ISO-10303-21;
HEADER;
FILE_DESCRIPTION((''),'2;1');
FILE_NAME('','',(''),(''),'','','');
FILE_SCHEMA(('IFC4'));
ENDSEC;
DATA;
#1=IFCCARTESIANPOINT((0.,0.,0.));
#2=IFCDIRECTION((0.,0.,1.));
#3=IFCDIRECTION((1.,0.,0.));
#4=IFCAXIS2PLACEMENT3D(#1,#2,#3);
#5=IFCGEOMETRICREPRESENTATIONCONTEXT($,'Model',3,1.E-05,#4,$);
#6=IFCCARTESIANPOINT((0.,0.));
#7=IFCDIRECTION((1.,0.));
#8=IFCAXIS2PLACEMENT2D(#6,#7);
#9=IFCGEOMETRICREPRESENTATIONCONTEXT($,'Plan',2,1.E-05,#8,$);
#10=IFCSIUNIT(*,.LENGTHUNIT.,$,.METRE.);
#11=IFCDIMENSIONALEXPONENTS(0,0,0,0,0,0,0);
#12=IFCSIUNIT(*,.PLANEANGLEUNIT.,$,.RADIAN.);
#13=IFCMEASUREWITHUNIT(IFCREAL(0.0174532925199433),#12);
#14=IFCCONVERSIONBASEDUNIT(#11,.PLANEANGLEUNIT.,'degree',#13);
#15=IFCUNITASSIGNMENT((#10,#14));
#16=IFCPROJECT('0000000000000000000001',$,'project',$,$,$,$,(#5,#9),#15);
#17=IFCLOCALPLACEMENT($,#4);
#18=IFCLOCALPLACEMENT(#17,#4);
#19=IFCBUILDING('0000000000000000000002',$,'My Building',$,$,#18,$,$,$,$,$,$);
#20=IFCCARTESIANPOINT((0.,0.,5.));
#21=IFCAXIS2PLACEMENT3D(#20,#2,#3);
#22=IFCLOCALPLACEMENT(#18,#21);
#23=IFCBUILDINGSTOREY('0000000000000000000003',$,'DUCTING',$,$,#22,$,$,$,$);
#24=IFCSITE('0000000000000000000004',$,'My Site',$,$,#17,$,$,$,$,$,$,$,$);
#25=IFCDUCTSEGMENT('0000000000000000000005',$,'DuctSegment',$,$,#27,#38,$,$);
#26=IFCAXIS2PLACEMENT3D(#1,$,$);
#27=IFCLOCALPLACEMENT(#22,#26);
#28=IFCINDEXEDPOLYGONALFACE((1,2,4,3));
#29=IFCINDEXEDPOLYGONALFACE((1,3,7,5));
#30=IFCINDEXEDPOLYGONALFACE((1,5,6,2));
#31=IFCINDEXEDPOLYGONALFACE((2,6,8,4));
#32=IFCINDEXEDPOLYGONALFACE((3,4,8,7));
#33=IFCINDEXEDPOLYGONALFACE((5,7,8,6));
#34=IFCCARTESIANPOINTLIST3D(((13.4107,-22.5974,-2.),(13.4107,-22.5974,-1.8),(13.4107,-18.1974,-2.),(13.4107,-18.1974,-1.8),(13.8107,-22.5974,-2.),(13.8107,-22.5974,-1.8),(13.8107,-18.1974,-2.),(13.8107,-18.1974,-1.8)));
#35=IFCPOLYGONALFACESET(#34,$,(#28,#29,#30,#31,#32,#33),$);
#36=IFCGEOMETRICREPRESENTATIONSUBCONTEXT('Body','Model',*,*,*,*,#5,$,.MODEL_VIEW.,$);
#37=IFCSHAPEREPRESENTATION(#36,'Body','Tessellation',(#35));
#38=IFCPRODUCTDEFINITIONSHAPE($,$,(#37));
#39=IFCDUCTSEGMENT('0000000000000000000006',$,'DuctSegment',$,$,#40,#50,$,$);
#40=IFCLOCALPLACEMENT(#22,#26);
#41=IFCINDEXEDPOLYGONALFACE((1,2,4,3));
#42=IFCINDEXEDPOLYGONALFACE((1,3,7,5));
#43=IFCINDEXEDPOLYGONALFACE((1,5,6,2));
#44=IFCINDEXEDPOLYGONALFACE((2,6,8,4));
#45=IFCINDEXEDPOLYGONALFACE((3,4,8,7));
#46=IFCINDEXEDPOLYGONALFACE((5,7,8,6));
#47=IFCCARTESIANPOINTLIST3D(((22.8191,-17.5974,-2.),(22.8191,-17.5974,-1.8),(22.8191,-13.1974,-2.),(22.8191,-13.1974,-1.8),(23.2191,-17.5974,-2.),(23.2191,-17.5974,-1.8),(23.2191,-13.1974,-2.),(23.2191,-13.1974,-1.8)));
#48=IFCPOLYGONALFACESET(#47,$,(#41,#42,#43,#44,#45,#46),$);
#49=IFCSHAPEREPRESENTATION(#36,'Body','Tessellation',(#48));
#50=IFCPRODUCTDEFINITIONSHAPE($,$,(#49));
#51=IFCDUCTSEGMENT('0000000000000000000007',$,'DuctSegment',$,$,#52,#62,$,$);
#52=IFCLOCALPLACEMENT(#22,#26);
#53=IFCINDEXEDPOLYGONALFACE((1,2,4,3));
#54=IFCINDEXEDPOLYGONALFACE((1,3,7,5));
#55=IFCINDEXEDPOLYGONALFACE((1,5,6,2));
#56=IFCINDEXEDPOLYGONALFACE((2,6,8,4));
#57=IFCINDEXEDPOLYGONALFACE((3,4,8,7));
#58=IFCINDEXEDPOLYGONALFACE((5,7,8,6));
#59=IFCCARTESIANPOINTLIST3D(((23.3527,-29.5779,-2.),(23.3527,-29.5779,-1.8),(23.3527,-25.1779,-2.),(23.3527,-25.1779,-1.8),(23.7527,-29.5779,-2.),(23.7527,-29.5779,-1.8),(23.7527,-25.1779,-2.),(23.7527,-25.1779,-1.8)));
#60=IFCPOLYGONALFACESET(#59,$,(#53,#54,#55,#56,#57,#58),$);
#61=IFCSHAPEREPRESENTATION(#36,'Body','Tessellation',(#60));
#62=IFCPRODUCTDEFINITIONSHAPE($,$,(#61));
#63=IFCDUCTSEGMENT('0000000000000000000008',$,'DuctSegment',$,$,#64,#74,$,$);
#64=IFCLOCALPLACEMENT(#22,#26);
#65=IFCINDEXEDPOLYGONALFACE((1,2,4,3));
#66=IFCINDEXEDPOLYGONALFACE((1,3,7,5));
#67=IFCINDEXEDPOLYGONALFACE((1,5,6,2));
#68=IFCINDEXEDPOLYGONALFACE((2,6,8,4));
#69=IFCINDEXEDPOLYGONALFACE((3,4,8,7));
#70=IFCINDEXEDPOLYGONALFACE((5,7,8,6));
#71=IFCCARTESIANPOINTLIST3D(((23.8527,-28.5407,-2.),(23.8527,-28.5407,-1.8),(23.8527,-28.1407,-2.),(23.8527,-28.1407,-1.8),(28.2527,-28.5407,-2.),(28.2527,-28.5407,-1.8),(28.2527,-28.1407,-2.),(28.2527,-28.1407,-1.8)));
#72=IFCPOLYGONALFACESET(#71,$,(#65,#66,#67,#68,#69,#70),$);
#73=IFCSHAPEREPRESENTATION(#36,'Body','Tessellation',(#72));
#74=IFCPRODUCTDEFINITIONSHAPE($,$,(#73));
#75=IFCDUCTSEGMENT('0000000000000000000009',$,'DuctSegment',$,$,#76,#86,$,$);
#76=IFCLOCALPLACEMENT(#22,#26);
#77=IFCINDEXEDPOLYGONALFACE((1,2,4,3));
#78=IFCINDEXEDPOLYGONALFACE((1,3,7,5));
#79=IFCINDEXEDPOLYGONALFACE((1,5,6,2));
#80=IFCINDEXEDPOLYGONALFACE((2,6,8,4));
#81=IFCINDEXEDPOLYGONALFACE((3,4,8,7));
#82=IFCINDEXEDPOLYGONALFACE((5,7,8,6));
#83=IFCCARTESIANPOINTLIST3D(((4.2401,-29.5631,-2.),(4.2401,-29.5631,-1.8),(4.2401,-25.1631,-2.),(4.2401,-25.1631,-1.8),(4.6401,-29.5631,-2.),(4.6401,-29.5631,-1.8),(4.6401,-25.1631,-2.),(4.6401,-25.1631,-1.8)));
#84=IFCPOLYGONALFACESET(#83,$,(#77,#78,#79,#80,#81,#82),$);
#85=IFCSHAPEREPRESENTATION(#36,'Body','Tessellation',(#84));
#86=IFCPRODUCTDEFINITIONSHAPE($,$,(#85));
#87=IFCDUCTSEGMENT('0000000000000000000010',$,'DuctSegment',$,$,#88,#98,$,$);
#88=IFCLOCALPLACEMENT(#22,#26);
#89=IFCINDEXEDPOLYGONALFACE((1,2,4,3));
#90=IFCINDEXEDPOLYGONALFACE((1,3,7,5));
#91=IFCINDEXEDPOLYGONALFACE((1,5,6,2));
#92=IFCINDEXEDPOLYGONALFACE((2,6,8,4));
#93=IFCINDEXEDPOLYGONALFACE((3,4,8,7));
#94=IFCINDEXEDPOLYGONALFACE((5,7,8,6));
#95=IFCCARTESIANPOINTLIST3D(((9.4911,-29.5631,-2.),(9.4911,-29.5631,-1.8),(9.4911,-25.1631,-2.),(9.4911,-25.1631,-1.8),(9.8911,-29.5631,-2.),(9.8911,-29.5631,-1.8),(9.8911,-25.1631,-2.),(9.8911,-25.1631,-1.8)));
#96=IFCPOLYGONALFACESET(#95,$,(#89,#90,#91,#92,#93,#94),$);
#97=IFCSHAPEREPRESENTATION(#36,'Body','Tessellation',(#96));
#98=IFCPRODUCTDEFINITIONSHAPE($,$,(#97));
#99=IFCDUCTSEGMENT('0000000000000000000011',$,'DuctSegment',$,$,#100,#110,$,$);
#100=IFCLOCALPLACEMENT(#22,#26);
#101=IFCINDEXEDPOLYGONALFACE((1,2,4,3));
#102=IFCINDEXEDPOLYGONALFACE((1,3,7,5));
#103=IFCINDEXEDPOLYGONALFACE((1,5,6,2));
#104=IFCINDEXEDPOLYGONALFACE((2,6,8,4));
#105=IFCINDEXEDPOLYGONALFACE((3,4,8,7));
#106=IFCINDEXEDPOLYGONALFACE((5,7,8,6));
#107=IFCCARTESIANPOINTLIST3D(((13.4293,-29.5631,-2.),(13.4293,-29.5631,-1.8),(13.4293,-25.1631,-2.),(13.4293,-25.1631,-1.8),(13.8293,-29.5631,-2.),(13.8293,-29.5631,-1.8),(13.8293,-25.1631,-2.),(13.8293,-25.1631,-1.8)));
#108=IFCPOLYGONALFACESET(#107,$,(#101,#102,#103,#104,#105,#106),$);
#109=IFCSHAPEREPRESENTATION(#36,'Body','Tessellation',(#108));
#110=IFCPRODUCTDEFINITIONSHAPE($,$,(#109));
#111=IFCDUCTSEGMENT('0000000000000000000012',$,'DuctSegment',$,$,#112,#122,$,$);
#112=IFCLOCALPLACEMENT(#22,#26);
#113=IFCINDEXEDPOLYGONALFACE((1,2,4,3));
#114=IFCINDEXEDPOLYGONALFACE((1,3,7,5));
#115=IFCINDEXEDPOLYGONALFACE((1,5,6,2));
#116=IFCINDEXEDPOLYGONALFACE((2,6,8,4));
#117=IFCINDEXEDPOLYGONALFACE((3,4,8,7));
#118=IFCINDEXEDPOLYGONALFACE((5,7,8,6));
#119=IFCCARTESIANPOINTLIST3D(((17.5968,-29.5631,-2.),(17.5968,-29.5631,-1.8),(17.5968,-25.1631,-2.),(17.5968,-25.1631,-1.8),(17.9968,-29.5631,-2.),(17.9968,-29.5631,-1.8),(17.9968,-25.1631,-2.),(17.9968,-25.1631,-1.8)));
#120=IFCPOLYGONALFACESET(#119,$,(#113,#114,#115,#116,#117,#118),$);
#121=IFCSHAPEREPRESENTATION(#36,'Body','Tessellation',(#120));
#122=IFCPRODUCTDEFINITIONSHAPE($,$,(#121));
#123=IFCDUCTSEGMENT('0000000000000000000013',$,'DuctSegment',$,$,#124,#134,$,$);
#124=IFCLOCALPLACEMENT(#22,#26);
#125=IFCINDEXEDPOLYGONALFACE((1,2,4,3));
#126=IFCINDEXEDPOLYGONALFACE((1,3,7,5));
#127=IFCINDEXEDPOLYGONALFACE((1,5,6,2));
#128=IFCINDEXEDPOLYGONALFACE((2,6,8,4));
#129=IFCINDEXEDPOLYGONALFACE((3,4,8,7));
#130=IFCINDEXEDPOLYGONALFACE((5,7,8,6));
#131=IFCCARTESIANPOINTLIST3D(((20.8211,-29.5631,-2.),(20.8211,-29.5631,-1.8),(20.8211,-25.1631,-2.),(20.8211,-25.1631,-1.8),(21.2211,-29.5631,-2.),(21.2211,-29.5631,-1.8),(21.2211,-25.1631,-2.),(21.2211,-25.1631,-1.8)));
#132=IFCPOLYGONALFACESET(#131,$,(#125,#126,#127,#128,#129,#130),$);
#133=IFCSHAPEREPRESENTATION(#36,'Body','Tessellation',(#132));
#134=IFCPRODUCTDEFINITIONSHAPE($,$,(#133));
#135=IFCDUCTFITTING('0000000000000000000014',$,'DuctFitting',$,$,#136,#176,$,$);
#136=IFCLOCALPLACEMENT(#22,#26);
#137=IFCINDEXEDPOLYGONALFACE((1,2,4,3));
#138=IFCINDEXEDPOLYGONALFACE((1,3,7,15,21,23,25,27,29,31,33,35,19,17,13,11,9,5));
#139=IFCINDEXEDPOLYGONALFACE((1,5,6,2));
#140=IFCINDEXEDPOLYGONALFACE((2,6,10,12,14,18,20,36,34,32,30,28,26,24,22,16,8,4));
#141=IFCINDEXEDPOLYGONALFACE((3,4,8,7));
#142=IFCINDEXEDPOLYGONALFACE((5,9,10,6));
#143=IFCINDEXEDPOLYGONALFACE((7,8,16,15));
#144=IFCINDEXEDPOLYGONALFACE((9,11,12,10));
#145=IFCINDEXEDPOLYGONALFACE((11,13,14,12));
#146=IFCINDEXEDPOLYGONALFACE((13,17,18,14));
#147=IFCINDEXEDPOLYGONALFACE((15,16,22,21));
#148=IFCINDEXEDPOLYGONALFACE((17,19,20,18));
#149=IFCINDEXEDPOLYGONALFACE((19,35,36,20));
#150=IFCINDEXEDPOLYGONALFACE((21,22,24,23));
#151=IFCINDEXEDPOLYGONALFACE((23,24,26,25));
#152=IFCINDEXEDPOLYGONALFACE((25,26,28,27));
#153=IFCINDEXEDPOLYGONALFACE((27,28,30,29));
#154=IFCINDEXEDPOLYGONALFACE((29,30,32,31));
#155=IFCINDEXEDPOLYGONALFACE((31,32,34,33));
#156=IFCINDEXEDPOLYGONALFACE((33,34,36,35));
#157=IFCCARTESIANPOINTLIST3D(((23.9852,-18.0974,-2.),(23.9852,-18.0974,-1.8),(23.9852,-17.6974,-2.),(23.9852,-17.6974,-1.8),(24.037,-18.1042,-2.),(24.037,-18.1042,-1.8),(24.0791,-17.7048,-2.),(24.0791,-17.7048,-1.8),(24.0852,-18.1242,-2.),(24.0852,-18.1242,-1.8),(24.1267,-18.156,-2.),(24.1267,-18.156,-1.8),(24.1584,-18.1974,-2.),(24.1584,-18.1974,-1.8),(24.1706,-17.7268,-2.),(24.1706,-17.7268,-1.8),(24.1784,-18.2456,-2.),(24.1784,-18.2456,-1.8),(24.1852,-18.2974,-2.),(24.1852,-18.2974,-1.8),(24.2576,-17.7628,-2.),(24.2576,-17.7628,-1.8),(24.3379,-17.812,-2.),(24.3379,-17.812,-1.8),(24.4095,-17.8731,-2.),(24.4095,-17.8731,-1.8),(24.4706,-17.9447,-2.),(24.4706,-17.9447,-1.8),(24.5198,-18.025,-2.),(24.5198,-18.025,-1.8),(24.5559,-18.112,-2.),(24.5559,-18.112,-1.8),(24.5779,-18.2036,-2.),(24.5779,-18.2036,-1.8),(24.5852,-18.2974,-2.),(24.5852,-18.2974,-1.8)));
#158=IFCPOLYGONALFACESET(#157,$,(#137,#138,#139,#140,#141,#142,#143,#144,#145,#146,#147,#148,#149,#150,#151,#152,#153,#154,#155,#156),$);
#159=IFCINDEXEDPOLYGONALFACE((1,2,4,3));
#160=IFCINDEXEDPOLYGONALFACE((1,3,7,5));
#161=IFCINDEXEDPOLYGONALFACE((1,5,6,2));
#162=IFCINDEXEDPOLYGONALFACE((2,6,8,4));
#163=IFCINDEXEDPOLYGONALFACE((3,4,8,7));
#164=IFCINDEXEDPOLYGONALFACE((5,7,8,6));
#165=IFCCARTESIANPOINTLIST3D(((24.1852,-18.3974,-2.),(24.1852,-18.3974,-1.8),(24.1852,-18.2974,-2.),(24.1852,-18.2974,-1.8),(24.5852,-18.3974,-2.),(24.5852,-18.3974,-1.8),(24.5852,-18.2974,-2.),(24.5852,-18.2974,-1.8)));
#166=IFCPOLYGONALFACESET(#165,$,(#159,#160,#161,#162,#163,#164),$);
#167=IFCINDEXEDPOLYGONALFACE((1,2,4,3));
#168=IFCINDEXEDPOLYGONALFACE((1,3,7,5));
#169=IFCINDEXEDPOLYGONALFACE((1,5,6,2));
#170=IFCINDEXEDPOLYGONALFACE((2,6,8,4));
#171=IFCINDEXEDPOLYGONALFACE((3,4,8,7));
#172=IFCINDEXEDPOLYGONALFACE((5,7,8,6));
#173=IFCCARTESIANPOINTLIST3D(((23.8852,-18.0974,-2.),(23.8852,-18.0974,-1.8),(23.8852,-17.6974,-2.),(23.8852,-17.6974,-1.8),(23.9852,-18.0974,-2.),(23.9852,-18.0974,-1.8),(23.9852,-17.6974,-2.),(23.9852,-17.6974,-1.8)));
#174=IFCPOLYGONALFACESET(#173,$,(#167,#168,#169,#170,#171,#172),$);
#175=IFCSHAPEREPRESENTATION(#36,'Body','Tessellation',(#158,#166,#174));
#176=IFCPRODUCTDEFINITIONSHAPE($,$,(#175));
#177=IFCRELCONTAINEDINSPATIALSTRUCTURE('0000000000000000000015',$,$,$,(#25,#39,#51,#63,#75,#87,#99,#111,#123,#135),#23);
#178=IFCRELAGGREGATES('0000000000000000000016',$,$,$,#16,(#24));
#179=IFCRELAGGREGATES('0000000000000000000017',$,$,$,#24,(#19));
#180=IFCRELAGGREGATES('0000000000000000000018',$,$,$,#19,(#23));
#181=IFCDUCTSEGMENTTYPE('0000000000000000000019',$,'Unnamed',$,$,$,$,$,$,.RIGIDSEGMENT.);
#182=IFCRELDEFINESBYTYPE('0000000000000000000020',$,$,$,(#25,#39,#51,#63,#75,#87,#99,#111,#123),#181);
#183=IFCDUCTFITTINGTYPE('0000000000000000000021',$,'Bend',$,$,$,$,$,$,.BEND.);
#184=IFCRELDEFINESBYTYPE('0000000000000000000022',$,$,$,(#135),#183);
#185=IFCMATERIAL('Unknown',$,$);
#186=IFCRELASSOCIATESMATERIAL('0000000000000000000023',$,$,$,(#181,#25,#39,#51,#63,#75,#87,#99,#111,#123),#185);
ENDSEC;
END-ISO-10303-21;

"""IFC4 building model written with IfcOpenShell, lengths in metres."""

from ifc_helpers import new_model, entity, si_unit, converted_unit, frame, origin_with_axes, origin_2d_with_axis, place, context, subcontext, project, spatial, line, arc, indexed_curve, rectangle, outline, extrude, source, transform, mapped, material, material_profile, profile_set, profile_usage, type_object, type_shapes, element, save


model = new_model("IFC4")

# Units and contexts
model_context = context("Model", 3, precision=1e-05, world=origin_with_axes())
plan_context = context("Plan", 2, precision=1e-05, world=origin_2d_with_axis())
body_context = subcontext(model_context, "Body", "Model", "MODEL_VIEW")
ifc_project = project(units=[si_unit("LENGTHUNIT", "METRE"), converted_unit("PLANEANGLEUNIT", "degree", entity("IfcReal", 0.0174532925199433), si_unit("PLANEANGLEUNIT", "RADIAN"), dimensions=[0, 0, 0, 0, 0, 0, 0])], contexts=[model_context, plan_context])

# Site, building, storey
site_placement = place(None, origin_with_axes())
site = spatial("IfcSite", under=ifc_project, at=site_placement, Name="My Site")
building_placement = place(site_placement, origin_with_axes())
building = spatial("IfcBuilding", under=site, at=building_placement, Name="My Building")
storey_placement = place(building_placement, frame((0.0, 0.0, 5.0), z_axis=(0.0, 0.0, 1.0), x_axis=(1.0, 0.0, 0.0)))
storey = spatial("IfcBuildingStorey", under=building, at=storey_placement, Name="DUCTING")

# Duct segments
ifc_material = material(Name="Unknown")
ifc_material_profile = material_profile(ifc_material, rectangle(XDim=0.4, YDim=0.2))
ifc_profile_set = profile_set([ifc_material_profile])
duct_segment_type = type_object("IfcDuctSegmentType", Name="Unnamed", PredefinedType="RIGIDSEGMENT", material=ifc_profile_set)
ifc_profile_usage_1 = profile_usage(ifc_profile_set, cardinal=5)
duct_segment_1_placement = place(storey_placement, frame((13.6107, -22.5974, -1.9), z_axis=(0.0, 1.0, -0.000003), x_axis=(-1.0, 0.0, 0.0)))
element("IfcDuctSegment", 1, at=duct_segment_1_placement, inside=storey, type_object=duct_segment_type, material=ifc_profile_usage_1, Name="DuctSegment", context=body_context, shape_type="SweptSolid", body=[
    extrude(rectangle(XDim=0.4, YDim=0.2), origin_with_axes(), (0.0, 0.0, 1.0), 4.4),
])
ifc_profile_usage_2 = profile_usage(ifc_profile_set, cardinal=5)
duct_segment_2_placement = place(storey_placement, frame((23.0191, -17.5974, -1.9), z_axis=(0.0, 1.0, -0.000003), x_axis=(-1.0, 0.0, 0.0)))
element("IfcDuctSegment", 2, at=duct_segment_2_placement, inside=storey, type_object=duct_segment_type, material=ifc_profile_usage_2, Name="DuctSegment", context=body_context, shape_type="SweptSolid", body=[
    extrude(rectangle(XDim=0.4, YDim=0.2), origin_with_axes(), (0.0, 0.0, 1.0), 4.4),
])
ifc_profile_usage_3 = profile_usage(ifc_profile_set, cardinal=5)
duct_segment_3_placement = place(storey_placement, frame((23.5527, -29.5779, -1.9), z_axis=(0.0, 1.0, -0.000003), x_axis=(-1.0, 0.0, 0.0)))
element("IfcDuctSegment", 3, at=duct_segment_3_placement, inside=storey, type_object=duct_segment_type, material=ifc_profile_usage_3, Name="DuctSegment", context=body_context, shape_type="SweptSolid", body=[
    extrude(rectangle(XDim=0.4, YDim=0.2), origin_with_axes(), (0.0, 0.0, 1.0), 4.4),
])
ifc_profile_usage_4 = profile_usage(ifc_profile_set, cardinal=5)
duct_segment_4_placement = place(storey_placement, frame((28.2527, -28.3407, -1.9), z_axis=(-1.0, 0.0, -0.000003), x_axis=(0.0, -1.0, 0.0)))
element("IfcDuctSegment", 4, at=duct_segment_4_placement, inside=storey, type_object=duct_segment_type, material=ifc_profile_usage_4, Name="DuctSegment", context=body_context, shape_type="SweptSolid", body=[
    extrude(rectangle(XDim=0.4, YDim=0.2), origin_with_axes(), (0.0, 0.0, 1.0), 4.4),
])
ifc_profile_usage_5 = profile_usage(ifc_profile_set, cardinal=5)
duct_segment_5_placement = place(storey_placement, frame((4.4401, -29.5631, -1.9), z_axis=(0.0, 1.0, -0.000003), x_axis=(-1.0, 0.0, 0.0)))
element("IfcDuctSegment", 5, at=duct_segment_5_placement, inside=storey, type_object=duct_segment_type, material=ifc_profile_usage_5, Name="DuctSegment", context=body_context, shape_type="SweptSolid", body=[
    extrude(rectangle(XDim=0.4, YDim=0.2), origin_with_axes(), (0.0, 0.0, 1.0), 4.4),
])
ifc_profile_usage_6 = profile_usage(ifc_profile_set, cardinal=5)
duct_segment_6_placement = place(storey_placement, frame((9.6911, -29.5631, -1.9), z_axis=(0.0, 1.0, -0.000003), x_axis=(-1.0, 0.0, 0.0)))
element("IfcDuctSegment", 6, at=duct_segment_6_placement, inside=storey, type_object=duct_segment_type, material=ifc_profile_usage_6, Name="DuctSegment", context=body_context, shape_type="SweptSolid", body=[
    extrude(rectangle(XDim=0.4, YDim=0.2), origin_with_axes(), (0.0, 0.0, 1.0), 4.4),
])
ifc_profile_usage_7 = profile_usage(ifc_profile_set, cardinal=5)
duct_segment_7_placement = place(storey_placement, frame((13.6293, -29.5631, -1.9), z_axis=(0.0, 1.0, -0.000003), x_axis=(-1.0, 0.0, 0.0)))
element("IfcDuctSegment", 7, at=duct_segment_7_placement, inside=storey, type_object=duct_segment_type, material=ifc_profile_usage_7, Name="DuctSegment", context=body_context, shape_type="SweptSolid", body=[
    extrude(rectangle(XDim=0.4, YDim=0.2), origin_with_axes(), (0.0, 0.0, 1.0), 4.4),
])
ifc_profile_usage_8 = profile_usage(ifc_profile_set, cardinal=5)
duct_segment_8_placement = place(storey_placement, frame((17.7968, -29.5631, -1.9), z_axis=(0.0, 1.0, -0.000003), x_axis=(-1.0, 0.0, 0.0)))
element("IfcDuctSegment", 8, at=duct_segment_8_placement, inside=storey, type_object=duct_segment_type, material=ifc_profile_usage_8, Name="DuctSegment", context=body_context, shape_type="SweptSolid", body=[
    extrude(rectangle(XDim=0.4, YDim=0.2), origin_with_axes(), (0.0, 0.0, 1.0), 4.4),
])
ifc_profile_usage_9 = profile_usage(ifc_profile_set, cardinal=5)
duct_segment_9_placement = place(storey_placement, frame((21.0211, -29.5631, -1.9), z_axis=(0.0, 1.0, -0.000003), x_axis=(-1.0, 0.0, 0.0)))
element("IfcDuctSegment", 9, at=duct_segment_9_placement, inside=storey, type_object=duct_segment_type, material=ifc_profile_usage_9, Name="DuctSegment", context=body_context, shape_type="SweptSolid", body=[
    extrude(rectangle(XDim=0.4, YDim=0.2), origin_with_axes(), (0.0, 0.0, 1.0), 4.4),
])

# Duct fitting
duct_fitting_type = type_object("IfcDuctFittingType", Name="Bend", PredefinedType="BEND")
shared_shape = source(origin_with_axes(), body_context, "Body", "SweptSolid", [
    extrude(outline(indexed_curve([(-0.2, 0.0), (-0.2586, -0.1414), (-0.4, -0.2), (-0.4, -0.6), (0.0243, -0.4243), (0.2, 0.0)], segments=[arc(1, 2, 3), line(3, 4), arc(4, 5, 6), line(6, 1)])), frame((0.0, -0.1, -0.1), z_axis=(0.0, -1.0, 0.0), x_axis=(1.0, 0.0, 0.0)), (0.0, 0.0, -1.0), 0.2),
    extrude(rectangle(XDim=0.4, YDim=0.2), origin_with_axes(), (0.0, 0.0, -1.0), 0.1),
    extrude(rectangle(XDim=0.4, YDim=0.2), frame((-0.4, 0.0, -0.5), z_axis=(-1.0, 0.0, 0.0), x_axis=(0.0, 0.0, -1.0)), (0.0, 0.0, 1.0), 0.1),
])
type_shapes(duct_fitting_type, [shared_shape])
for number, where, z_axis, x_axis, name in (
    (10, (24.3852, -18.3974, -1.9), (0.0, -1.0, 0.0), (1.0, 0.0, 0.0), "DuctFitting"),
):
    element("IfcDuctFitting", number, at=place(storey_placement, frame(where, z_axis=z_axis, x_axis=x_axis)), inside=storey, type_object=duct_fitting_type, Name=name, context=body_context, shape_type="MappedRepresentation", body=[
        mapped(shared_shape, transform((0.0, 0.0, 0.0), x_axis=(1.0, 0.0, 0.0), y_axis=(0.0, 1.0, 0.0), z_axis=(0.0, 0.0, 1.0), scale=1.0)),
    ])

save(model, "model.ifc")
